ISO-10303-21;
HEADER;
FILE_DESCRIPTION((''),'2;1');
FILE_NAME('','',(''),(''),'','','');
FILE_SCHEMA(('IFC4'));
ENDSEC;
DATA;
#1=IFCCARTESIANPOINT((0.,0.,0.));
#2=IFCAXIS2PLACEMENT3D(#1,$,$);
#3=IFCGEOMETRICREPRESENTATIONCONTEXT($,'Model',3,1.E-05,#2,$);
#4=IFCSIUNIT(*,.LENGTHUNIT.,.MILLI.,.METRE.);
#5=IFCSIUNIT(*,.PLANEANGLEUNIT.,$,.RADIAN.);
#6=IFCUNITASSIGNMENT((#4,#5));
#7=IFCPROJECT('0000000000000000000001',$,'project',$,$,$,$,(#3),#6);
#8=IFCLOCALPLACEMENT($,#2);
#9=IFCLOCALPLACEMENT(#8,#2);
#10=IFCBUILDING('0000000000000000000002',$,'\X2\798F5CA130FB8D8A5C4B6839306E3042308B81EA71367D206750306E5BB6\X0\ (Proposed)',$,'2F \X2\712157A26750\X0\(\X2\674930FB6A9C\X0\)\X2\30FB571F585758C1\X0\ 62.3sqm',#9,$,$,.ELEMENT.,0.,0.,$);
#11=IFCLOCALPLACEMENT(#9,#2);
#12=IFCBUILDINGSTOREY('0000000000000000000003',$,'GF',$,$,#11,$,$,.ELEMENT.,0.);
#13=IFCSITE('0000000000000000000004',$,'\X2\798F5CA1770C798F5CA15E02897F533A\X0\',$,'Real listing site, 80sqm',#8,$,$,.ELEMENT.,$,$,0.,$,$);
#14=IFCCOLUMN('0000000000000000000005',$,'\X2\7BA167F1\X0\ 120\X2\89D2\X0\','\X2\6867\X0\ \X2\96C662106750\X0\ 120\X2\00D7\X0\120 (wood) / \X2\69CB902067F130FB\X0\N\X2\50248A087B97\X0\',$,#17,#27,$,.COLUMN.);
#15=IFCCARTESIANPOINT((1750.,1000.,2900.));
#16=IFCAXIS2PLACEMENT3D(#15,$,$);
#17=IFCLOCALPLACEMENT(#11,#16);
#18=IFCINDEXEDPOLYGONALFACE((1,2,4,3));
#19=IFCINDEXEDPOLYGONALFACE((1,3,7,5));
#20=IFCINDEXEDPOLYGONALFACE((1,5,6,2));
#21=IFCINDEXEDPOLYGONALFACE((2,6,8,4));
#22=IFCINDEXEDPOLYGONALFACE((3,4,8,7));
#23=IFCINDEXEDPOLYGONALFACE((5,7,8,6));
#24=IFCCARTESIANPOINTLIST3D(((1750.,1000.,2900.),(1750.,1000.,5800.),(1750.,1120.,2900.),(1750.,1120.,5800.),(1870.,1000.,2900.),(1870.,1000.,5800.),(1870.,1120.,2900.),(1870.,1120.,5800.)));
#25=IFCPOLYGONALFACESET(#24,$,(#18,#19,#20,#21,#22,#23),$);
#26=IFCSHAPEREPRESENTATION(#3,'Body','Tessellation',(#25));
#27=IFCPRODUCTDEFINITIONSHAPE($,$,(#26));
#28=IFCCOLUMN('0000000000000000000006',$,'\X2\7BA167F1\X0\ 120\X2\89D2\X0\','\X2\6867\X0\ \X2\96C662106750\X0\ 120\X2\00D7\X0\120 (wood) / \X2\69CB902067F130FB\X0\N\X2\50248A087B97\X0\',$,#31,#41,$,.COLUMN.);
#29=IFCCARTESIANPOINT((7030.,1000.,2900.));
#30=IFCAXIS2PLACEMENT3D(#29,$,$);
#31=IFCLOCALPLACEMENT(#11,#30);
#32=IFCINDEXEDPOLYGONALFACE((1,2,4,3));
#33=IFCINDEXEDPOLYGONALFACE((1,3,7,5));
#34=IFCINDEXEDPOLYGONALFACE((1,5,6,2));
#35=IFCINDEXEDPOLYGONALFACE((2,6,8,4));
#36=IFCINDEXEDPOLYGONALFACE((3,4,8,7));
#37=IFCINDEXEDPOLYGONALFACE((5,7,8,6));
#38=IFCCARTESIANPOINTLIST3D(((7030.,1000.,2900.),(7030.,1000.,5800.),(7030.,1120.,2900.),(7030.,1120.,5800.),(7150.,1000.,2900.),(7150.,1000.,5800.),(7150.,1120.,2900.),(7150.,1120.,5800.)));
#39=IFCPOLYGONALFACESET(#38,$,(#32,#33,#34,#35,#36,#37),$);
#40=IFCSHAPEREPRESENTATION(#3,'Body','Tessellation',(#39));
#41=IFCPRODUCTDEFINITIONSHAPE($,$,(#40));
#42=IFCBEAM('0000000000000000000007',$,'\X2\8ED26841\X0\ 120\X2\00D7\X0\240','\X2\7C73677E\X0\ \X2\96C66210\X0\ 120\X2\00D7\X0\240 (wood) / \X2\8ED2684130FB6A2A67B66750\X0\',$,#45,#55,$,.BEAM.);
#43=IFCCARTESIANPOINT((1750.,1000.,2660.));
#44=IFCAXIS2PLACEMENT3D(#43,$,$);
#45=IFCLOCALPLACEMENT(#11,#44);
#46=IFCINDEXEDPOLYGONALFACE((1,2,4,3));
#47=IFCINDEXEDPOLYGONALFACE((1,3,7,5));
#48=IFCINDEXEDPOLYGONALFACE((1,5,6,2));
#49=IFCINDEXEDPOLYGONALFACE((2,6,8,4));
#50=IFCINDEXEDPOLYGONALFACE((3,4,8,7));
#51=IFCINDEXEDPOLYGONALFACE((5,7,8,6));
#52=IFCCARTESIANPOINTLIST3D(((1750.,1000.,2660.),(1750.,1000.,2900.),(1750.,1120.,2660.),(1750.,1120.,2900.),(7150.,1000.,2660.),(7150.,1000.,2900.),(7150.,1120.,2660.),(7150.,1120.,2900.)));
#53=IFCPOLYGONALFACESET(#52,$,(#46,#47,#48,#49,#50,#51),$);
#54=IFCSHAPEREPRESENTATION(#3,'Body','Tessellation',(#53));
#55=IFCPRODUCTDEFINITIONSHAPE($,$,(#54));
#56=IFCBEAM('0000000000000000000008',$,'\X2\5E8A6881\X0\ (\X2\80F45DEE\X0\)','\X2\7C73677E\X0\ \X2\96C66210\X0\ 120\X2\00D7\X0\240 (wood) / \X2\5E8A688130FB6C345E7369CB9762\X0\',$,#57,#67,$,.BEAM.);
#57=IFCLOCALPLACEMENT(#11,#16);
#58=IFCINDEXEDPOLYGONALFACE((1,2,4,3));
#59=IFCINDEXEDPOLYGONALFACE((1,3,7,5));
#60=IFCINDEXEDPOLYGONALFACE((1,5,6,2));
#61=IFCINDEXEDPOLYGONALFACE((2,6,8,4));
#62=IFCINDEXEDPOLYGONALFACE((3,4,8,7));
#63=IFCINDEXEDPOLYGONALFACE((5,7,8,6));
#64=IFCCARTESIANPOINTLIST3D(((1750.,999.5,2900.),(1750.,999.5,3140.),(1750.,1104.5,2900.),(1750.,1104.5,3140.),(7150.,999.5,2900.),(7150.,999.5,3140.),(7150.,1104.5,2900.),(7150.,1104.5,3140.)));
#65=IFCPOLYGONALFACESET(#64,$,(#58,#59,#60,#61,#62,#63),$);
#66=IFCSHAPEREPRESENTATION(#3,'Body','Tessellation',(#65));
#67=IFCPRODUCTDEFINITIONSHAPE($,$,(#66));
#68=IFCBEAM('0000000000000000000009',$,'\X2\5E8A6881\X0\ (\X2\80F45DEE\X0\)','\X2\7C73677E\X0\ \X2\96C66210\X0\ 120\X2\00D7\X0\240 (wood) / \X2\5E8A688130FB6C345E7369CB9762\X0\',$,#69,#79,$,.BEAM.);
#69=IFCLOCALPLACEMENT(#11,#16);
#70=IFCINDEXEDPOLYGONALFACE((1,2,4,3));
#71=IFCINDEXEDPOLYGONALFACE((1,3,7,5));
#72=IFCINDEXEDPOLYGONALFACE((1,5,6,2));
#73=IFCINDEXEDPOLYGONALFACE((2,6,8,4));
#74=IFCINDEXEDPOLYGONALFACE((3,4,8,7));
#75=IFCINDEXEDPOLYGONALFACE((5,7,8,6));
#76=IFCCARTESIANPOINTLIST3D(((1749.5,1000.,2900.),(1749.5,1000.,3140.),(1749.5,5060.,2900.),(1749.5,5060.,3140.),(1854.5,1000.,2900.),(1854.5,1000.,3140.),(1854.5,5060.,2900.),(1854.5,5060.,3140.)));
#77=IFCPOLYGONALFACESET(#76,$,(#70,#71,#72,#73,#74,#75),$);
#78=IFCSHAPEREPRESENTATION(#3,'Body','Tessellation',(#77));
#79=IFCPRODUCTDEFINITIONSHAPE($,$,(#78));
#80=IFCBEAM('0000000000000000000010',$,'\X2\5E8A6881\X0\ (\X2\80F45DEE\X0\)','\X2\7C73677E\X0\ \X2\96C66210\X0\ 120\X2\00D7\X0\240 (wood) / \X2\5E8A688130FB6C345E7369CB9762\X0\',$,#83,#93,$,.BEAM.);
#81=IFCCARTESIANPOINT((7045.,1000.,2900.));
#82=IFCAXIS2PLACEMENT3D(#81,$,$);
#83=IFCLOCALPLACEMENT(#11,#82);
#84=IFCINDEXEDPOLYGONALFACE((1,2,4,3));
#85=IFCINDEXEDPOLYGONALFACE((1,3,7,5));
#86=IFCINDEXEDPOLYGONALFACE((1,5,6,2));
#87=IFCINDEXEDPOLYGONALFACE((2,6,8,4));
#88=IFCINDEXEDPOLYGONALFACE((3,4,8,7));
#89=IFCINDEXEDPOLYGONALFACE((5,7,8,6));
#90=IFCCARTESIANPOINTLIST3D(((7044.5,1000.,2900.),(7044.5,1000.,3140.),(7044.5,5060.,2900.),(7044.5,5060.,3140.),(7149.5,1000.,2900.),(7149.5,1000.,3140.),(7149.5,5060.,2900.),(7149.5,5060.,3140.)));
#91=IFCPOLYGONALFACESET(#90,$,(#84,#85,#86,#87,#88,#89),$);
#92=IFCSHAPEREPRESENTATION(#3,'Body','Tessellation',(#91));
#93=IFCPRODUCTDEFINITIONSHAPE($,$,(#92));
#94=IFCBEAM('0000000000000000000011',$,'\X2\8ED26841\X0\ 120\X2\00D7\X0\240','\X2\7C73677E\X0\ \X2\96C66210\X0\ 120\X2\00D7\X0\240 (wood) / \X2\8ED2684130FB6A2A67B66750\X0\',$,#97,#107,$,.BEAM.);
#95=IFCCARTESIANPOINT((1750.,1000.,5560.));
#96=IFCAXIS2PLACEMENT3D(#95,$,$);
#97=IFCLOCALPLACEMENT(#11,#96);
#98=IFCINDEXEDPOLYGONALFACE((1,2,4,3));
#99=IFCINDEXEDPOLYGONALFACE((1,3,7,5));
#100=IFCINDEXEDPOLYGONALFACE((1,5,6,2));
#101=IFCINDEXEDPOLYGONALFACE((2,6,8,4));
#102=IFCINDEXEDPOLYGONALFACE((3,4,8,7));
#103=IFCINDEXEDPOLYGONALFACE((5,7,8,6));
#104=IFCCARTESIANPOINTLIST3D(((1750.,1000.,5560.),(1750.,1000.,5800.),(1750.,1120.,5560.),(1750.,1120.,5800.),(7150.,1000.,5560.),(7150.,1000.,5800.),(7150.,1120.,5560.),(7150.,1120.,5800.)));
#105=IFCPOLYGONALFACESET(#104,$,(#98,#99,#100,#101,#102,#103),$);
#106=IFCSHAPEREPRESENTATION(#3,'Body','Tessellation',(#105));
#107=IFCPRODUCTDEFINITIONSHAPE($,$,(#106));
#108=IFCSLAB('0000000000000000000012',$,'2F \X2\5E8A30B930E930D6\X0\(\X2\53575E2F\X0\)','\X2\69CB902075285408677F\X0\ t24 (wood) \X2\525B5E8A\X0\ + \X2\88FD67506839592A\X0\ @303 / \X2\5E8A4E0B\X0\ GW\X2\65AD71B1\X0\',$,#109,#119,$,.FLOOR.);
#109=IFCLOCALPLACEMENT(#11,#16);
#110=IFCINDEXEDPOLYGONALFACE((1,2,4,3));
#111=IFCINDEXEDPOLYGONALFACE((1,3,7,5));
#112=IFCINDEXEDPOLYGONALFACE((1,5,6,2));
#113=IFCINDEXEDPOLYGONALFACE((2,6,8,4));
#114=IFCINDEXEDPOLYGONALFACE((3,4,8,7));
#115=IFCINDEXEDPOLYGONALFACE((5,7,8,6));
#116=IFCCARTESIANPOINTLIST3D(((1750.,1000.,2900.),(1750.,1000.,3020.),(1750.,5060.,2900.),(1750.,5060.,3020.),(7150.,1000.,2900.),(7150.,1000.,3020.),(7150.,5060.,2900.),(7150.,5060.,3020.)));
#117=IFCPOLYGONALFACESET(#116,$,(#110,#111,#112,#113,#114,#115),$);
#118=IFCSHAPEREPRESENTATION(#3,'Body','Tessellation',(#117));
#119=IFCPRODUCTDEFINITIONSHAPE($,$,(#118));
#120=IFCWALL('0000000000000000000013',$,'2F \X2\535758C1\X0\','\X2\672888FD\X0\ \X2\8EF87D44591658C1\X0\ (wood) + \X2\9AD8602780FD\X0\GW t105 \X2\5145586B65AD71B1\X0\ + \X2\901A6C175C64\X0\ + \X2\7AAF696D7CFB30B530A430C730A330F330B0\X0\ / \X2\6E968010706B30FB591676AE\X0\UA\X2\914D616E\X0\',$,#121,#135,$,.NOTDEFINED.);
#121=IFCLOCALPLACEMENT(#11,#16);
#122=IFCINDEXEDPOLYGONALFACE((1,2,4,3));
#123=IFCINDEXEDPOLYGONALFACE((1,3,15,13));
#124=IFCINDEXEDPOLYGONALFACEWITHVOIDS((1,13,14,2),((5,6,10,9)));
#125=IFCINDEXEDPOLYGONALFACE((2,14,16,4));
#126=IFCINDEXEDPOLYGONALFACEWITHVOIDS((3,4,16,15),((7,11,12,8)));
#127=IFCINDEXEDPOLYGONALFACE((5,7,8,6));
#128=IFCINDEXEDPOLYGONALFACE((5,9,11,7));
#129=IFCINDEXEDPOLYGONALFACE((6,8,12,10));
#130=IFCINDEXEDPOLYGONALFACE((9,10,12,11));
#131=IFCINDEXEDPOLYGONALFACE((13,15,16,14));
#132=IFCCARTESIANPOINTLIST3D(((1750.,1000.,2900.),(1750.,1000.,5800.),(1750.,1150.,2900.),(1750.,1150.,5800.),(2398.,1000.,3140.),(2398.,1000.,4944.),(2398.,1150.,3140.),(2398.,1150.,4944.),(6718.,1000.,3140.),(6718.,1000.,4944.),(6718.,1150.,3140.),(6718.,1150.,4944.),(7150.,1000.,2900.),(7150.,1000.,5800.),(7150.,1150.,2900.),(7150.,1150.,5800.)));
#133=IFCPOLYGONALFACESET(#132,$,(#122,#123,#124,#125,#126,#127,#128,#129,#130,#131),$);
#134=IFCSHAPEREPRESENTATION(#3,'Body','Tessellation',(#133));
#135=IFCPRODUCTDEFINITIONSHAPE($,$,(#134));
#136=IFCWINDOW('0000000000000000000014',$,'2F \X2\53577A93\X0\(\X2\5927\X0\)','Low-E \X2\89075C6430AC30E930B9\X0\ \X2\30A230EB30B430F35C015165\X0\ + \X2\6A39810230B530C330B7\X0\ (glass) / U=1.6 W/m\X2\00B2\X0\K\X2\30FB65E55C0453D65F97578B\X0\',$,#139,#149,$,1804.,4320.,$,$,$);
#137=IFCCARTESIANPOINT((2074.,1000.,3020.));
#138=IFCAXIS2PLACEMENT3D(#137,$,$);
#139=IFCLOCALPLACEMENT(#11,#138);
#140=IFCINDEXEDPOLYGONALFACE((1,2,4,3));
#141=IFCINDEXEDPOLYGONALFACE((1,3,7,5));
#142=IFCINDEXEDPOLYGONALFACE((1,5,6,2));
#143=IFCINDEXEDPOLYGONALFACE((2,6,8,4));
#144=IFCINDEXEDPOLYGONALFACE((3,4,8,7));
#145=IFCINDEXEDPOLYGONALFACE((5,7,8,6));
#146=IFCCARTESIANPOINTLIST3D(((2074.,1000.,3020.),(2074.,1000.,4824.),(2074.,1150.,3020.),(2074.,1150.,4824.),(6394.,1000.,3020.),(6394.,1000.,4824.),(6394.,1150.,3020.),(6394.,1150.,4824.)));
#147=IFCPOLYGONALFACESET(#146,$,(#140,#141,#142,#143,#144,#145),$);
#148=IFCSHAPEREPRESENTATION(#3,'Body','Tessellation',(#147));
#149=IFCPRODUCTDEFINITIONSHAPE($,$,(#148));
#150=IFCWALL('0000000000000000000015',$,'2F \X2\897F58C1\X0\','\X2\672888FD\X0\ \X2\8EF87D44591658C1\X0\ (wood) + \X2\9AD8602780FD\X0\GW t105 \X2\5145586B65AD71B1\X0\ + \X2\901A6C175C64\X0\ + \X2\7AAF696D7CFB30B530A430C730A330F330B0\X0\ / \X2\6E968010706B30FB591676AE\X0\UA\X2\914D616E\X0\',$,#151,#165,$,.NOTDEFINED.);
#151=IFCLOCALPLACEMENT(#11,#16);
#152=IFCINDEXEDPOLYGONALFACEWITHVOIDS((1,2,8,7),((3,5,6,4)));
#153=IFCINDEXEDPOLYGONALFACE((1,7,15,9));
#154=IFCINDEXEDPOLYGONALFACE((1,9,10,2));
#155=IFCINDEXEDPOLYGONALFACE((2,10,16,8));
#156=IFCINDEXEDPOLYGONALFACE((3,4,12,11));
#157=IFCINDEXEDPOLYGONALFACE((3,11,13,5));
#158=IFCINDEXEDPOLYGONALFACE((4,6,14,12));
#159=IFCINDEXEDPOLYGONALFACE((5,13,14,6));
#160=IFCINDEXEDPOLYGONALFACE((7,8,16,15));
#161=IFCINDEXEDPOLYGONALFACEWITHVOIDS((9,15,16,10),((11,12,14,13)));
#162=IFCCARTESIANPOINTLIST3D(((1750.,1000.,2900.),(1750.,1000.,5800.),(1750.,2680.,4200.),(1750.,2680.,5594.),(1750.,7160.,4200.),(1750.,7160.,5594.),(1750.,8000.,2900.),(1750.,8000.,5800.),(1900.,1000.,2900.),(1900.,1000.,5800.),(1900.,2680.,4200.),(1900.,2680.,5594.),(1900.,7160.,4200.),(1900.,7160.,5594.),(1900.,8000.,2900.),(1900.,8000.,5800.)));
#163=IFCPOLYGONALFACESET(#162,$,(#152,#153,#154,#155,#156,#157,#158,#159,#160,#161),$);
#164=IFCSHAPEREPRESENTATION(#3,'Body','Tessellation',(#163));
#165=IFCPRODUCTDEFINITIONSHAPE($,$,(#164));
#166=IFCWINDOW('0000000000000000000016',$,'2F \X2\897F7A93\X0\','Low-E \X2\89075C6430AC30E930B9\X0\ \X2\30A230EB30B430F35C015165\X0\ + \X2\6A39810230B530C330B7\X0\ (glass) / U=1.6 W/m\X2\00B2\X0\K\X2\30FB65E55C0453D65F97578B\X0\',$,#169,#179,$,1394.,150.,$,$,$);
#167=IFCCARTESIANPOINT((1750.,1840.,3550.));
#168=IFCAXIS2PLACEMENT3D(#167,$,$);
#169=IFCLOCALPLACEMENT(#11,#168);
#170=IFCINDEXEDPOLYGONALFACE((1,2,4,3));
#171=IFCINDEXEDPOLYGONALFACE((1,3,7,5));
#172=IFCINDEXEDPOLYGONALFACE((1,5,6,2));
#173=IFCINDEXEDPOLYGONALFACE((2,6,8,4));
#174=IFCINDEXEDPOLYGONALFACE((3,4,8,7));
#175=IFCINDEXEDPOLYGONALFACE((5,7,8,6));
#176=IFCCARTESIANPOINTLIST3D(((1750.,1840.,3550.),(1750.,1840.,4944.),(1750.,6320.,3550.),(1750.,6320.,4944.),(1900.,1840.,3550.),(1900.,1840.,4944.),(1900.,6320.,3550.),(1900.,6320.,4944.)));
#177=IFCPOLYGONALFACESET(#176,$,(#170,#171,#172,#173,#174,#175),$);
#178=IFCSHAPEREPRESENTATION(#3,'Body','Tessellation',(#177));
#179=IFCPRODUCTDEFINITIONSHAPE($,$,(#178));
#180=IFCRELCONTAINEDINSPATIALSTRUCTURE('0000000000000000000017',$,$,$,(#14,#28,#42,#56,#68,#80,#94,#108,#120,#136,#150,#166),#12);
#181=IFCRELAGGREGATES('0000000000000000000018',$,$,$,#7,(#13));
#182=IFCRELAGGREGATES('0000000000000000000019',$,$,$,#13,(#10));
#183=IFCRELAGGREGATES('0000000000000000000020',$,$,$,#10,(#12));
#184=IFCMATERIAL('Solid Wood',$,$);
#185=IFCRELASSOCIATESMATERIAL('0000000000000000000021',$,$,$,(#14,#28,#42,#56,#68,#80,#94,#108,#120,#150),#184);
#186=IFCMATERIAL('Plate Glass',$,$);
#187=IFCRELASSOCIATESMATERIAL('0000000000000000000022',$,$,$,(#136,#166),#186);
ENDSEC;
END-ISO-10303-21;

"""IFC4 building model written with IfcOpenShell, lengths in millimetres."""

from ifc_helpers import new_model, si_unit, frame, frame_2d, origin, place, context, project, spatial, rectangle, extrude, material, element, fill, save


model = new_model("IFC4")

# Units and contexts
model_context = context("Model", 3, precision=1e-05, world=origin())
ifc_project = project(units=[si_unit("LENGTHUNIT", "METRE", prefix="MILLI"), si_unit("PLANEANGLEUNIT", "RADIAN")], contexts=[model_context])

# Site, building, storey
site_placement = place(None, origin())
site = spatial("IfcSite", under=ifc_project, at=site_placement, Name="福岡県福岡市西区", ObjectType="Real listing site, 80sqm", CompositionType="ELEMENT", RefElevation=0.0)
building_placement = place(site_placement, origin())
building = spatial("IfcBuilding", under=site, at=building_placement, Name="福岡・越屋根のある自然素材の家 (Proposed)", ObjectType="2F 無垢材(杉・檜)・土塗壁 62.3sqm", CompositionType="ELEMENT", ElevationOfRefHeight=0.0, ElevationOfTerrain=0.0)
storey_placement = place(building_placement, origin())
storey = spatial("IfcBuildingStorey", under=building, at=storey_placement, Name="GF", CompositionType="ELEMENT", Elevation=0.0)

# Columns
ifc_material_1 = material(Name="Solid Wood")
column_1_placement = place(storey_placement, frame((1750.0, 1000.0, 2900.0)))
element("IfcColumn", 1, at=column_1_placement, inside=storey, material=ifc_material_1, Name="管柱 120角", Description="桧 集成材 120×120 (wood) / 構造柱・N値計算", PredefinedType="COLUMN", context=model_context, shape_type="SweptSolid", body=[
    extrude(rectangle(XDim=120.0, YDim=120.0, at=frame_2d((60.0, 60.0))), frame((1750.0, 1000.0, 2900.0)), (0.0, 0.0, 1.0), 2900.0),
])
column_2_placement = place(storey_placement, frame((7030.0, 1000.0, 2900.0)))
element("IfcColumn", 2, at=column_2_placement, inside=storey, material=ifc_material_1, Name="管柱 120角", Description="桧 集成材 120×120 (wood) / 構造柱・N値計算", PredefinedType="COLUMN", context=model_context, shape_type="SweptSolid", body=[
    extrude(rectangle(XDim=120.0, YDim=120.0, at=frame_2d((60.0, 60.0))), frame((7030.0, 1000.0, 2900.0)), (0.0, 0.0, 1.0), 2900.0),
])

# Beams
beam_1_placement = place(storey_placement, frame((1750.0, 1000.0, 2660.0)))
element("IfcBeam", 3, at=beam_1_placement, inside=storey, material=ifc_material_1, Name="軒桁 120×240", Description="米松 集成 120×240 (wood) / 軒桁・横架材", PredefinedType="BEAM", context=model_context, shape_type="SweptSolid", body=[
    extrude(rectangle(XDim=5400.0, YDim=120.0, at=frame_2d((2700.0, 60.0))), frame((1750.0, 1000.0, 2660.0)), (0.0, 0.0, 1.0), 240.0),
])
beam_2_placement = place(storey_placement, frame((1750.0, 1000.0, 2900.0)))
element("IfcBeam", 4, at=beam_2_placement, inside=storey, material=ifc_material_1, Name="床梁 (胴差)", Description="米松 集成 120×240 (wood) / 床梁・水平構面", PredefinedType="BEAM", context=model_context, shape_type="SweptSolid", body=[
    extrude(rectangle(XDim=5400.0, YDim=105.0, at=frame_2d((2700.0, 52.0))), frame((1750.0, 1000.0, 2900.0)), (0.0, 0.0, 1.0), 240.0),
])
beam_3_placement = place(storey_placement, frame((1750.0, 1000.0, 2900.0)))
element("IfcBeam", 5, at=beam_3_placement, inside=storey, material=ifc_material_1, Name="床梁 (胴差)", Description="米松 集成 120×240 (wood) / 床梁・水平構面", PredefinedType="BEAM", context=model_context, shape_type="SweptSolid", body=[
    extrude(rectangle(XDim=105.0, YDim=4060.0, at=frame_2d((52.0, 2030.0))), frame((1750.0, 1000.0, 2900.0)), (0.0, 0.0, 1.0), 240.0),
])
beam_4_placement = place(storey_placement, frame((7045.0, 1000.0, 2900.0)))
element("IfcBeam", 6, at=beam_4_placement, inside=storey, material=ifc_material_1, Name="床梁 (胴差)", Description="米松 集成 120×240 (wood) / 床梁・水平構面", PredefinedType="BEAM", context=model_context, shape_type="SweptSolid", body=[
    extrude(rectangle(XDim=105.0, YDim=4060.0, at=frame_2d((52.0, 2030.0))), frame((7045.0, 1000.0, 2900.0)), (0.0, 0.0, 1.0), 240.0),
])
beam_5_placement = place(storey_placement, frame((1750.0, 1000.0, 5560.0)))
element("IfcBeam", 7, at=beam_5_placement, inside=storey, material=ifc_material_1, Name="軒桁 120×240", Description="米松 集成 120×240 (wood) / 軒桁・横架材", PredefinedType="BEAM", context=model_context, shape_type="SweptSolid", body=[
    extrude(rectangle(XDim=5400.0, YDim=120.0, at=frame_2d((2700.0, 60.0))), frame((1750.0, 1000.0, 5560.0)), (0.0, 0.0, 1.0), 240.0),
])

# Slab
slab_placement = place(storey_placement, frame((1750.0, 1000.0, 2900.0)))
element("IfcSlab", 8, at=slab_placement, inside=storey, material=ifc_material_1, Name="2F 床スラブ(南帯)", Description="構造用合板 t24 (wood) 剛床 + 製材根太 @303 / 床下 GW断熱", PredefinedType="FLOOR", context=model_context, shape_type="SweptSolid", body=[
    extrude(rectangle(XDim=5400.0, YDim=4060.0, at=frame_2d((2700.0, 2030.0))), frame((1750.0, 1000.0, 2900.0)), (0.0, 0.0, 1.0), 120.0),
])

# Walls, openings, windows
wall_1_placement = place(storey_placement, frame((1750.0, 1000.0, 2900.0)))
wall_1 = element("IfcWall", 9, at=wall_1_placement, inside=storey, material=ifc_material_1, Name="2F 南壁", Description="木製 軸組外壁 (wood) + 高性能GW t105 充填断熱 + 通気層 + 窯業系サイディング / 準耐火・外皮UA配慮", PredefinedType="NOTDEFINED", context=model_context, shape_type="SweptSolid", body=[
    extrude(rectangle(XDim=5400.0, YDim=150.0, at=frame_2d((2700.0, 75.0))), frame((1750.0, 1000.0, 2900.0)), (0.0, 0.0, 1.0), 2900.0),
])
opening_1_placement = place(storey_placement, frame((2074.0, 1000.0, 3020.0)))
opening_1 = element("IfcOpeningElement", 10, at=opening_1_placement, cuts=wall_1, PredefinedType="NOTDEFINED", context=model_context, shape_type="SweptSolid", body=[
    extrude(rectangle(XDim=4320.0, YDim=150.0, at=frame_2d((2160.0, 75.0))), frame((2074.0, 1000.0, 3020.0)), (0.0, 0.0, 1.0), 1804.0),
])
ifc_material_2 = material(Name="Plate Glass")
window_1_placement = place(storey_placement, frame((2074.0, 1000.0, 3020.0)))
window_1 = element("IfcWindow", 11, at=window_1_placement, inside=storey, material=ifc_material_2, Name="2F 南窓(大)", Description="Low-E 複層ガラス アルゴン封入 + 樹脂サッシ (glass) / U=1.6 W/m²K・日射取得型", OverallHeight=1804.0, OverallWidth=4320.0, context=model_context, shape_type="SweptSolid", body=[
    extrude(rectangle(XDim=4320.0, YDim=150.0, at=frame_2d((2160.0, 75.0))), frame((2074.0, 1000.0, 3020.0)), (0.0, 0.0, 1.0), 1804.0),
])
fill(opening_1, window_1)
wall_2_placement = place(storey_placement, frame((1750.0, 1000.0, 2900.0)))
wall_2 = element("IfcWall", 12, at=wall_2_placement, inside=storey, material=ifc_material_1, Name="2F 西壁", Description="木製 軸組外壁 (wood) + 高性能GW t105 充填断熱 + 通気層 + 窯業系サイディング / 準耐火・外皮UA配慮", PredefinedType="NOTDEFINED", context=model_context, shape_type="SweptSolid", body=[
    extrude(rectangle(XDim=150.0, YDim=7000.0, at=frame_2d((75.0, 3500.0))), frame((1750.0, 1000.0, 2900.0)), (0.0, 0.0, 1.0), 2900.0),
])
opening_2_placement = place(storey_placement, frame((1750.0, 1840.0, 3550.0)))
opening_2 = element("IfcOpeningElement", 13, at=opening_2_placement, cuts=wall_2, PredefinedType="NOTDEFINED", context=model_context, shape_type="SweptSolid", body=[
    extrude(rectangle(XDim=150.0, YDim=4480.0, at=frame_2d((75.0, 2240.0))), frame((1750.0, 1840.0, 3550.0)), (0.0, 0.0, 1.0), 1394.0),
])
window_2_placement = place(storey_placement, frame((1750.0, 1840.0, 3550.0)))
window_2 = element("IfcWindow", 14, at=window_2_placement, inside=storey, material=ifc_material_2, Name="2F 西窓", Description="Low-E 複層ガラス アルゴン封入 + 樹脂サッシ (glass) / U=1.6 W/m²K・日射取得型", OverallHeight=1394.0, OverallWidth=150.0, context=model_context, shape_type="SweptSolid", body=[
    extrude(rectangle(XDim=150.0, YDim=4480.0, at=frame_2d((75.0, 2240.0))), frame((1750.0, 1840.0, 3550.0)), (0.0, 0.0, 1.0), 1394.0),
])
fill(opening_2, window_2)

save(model, "model.ifc")
